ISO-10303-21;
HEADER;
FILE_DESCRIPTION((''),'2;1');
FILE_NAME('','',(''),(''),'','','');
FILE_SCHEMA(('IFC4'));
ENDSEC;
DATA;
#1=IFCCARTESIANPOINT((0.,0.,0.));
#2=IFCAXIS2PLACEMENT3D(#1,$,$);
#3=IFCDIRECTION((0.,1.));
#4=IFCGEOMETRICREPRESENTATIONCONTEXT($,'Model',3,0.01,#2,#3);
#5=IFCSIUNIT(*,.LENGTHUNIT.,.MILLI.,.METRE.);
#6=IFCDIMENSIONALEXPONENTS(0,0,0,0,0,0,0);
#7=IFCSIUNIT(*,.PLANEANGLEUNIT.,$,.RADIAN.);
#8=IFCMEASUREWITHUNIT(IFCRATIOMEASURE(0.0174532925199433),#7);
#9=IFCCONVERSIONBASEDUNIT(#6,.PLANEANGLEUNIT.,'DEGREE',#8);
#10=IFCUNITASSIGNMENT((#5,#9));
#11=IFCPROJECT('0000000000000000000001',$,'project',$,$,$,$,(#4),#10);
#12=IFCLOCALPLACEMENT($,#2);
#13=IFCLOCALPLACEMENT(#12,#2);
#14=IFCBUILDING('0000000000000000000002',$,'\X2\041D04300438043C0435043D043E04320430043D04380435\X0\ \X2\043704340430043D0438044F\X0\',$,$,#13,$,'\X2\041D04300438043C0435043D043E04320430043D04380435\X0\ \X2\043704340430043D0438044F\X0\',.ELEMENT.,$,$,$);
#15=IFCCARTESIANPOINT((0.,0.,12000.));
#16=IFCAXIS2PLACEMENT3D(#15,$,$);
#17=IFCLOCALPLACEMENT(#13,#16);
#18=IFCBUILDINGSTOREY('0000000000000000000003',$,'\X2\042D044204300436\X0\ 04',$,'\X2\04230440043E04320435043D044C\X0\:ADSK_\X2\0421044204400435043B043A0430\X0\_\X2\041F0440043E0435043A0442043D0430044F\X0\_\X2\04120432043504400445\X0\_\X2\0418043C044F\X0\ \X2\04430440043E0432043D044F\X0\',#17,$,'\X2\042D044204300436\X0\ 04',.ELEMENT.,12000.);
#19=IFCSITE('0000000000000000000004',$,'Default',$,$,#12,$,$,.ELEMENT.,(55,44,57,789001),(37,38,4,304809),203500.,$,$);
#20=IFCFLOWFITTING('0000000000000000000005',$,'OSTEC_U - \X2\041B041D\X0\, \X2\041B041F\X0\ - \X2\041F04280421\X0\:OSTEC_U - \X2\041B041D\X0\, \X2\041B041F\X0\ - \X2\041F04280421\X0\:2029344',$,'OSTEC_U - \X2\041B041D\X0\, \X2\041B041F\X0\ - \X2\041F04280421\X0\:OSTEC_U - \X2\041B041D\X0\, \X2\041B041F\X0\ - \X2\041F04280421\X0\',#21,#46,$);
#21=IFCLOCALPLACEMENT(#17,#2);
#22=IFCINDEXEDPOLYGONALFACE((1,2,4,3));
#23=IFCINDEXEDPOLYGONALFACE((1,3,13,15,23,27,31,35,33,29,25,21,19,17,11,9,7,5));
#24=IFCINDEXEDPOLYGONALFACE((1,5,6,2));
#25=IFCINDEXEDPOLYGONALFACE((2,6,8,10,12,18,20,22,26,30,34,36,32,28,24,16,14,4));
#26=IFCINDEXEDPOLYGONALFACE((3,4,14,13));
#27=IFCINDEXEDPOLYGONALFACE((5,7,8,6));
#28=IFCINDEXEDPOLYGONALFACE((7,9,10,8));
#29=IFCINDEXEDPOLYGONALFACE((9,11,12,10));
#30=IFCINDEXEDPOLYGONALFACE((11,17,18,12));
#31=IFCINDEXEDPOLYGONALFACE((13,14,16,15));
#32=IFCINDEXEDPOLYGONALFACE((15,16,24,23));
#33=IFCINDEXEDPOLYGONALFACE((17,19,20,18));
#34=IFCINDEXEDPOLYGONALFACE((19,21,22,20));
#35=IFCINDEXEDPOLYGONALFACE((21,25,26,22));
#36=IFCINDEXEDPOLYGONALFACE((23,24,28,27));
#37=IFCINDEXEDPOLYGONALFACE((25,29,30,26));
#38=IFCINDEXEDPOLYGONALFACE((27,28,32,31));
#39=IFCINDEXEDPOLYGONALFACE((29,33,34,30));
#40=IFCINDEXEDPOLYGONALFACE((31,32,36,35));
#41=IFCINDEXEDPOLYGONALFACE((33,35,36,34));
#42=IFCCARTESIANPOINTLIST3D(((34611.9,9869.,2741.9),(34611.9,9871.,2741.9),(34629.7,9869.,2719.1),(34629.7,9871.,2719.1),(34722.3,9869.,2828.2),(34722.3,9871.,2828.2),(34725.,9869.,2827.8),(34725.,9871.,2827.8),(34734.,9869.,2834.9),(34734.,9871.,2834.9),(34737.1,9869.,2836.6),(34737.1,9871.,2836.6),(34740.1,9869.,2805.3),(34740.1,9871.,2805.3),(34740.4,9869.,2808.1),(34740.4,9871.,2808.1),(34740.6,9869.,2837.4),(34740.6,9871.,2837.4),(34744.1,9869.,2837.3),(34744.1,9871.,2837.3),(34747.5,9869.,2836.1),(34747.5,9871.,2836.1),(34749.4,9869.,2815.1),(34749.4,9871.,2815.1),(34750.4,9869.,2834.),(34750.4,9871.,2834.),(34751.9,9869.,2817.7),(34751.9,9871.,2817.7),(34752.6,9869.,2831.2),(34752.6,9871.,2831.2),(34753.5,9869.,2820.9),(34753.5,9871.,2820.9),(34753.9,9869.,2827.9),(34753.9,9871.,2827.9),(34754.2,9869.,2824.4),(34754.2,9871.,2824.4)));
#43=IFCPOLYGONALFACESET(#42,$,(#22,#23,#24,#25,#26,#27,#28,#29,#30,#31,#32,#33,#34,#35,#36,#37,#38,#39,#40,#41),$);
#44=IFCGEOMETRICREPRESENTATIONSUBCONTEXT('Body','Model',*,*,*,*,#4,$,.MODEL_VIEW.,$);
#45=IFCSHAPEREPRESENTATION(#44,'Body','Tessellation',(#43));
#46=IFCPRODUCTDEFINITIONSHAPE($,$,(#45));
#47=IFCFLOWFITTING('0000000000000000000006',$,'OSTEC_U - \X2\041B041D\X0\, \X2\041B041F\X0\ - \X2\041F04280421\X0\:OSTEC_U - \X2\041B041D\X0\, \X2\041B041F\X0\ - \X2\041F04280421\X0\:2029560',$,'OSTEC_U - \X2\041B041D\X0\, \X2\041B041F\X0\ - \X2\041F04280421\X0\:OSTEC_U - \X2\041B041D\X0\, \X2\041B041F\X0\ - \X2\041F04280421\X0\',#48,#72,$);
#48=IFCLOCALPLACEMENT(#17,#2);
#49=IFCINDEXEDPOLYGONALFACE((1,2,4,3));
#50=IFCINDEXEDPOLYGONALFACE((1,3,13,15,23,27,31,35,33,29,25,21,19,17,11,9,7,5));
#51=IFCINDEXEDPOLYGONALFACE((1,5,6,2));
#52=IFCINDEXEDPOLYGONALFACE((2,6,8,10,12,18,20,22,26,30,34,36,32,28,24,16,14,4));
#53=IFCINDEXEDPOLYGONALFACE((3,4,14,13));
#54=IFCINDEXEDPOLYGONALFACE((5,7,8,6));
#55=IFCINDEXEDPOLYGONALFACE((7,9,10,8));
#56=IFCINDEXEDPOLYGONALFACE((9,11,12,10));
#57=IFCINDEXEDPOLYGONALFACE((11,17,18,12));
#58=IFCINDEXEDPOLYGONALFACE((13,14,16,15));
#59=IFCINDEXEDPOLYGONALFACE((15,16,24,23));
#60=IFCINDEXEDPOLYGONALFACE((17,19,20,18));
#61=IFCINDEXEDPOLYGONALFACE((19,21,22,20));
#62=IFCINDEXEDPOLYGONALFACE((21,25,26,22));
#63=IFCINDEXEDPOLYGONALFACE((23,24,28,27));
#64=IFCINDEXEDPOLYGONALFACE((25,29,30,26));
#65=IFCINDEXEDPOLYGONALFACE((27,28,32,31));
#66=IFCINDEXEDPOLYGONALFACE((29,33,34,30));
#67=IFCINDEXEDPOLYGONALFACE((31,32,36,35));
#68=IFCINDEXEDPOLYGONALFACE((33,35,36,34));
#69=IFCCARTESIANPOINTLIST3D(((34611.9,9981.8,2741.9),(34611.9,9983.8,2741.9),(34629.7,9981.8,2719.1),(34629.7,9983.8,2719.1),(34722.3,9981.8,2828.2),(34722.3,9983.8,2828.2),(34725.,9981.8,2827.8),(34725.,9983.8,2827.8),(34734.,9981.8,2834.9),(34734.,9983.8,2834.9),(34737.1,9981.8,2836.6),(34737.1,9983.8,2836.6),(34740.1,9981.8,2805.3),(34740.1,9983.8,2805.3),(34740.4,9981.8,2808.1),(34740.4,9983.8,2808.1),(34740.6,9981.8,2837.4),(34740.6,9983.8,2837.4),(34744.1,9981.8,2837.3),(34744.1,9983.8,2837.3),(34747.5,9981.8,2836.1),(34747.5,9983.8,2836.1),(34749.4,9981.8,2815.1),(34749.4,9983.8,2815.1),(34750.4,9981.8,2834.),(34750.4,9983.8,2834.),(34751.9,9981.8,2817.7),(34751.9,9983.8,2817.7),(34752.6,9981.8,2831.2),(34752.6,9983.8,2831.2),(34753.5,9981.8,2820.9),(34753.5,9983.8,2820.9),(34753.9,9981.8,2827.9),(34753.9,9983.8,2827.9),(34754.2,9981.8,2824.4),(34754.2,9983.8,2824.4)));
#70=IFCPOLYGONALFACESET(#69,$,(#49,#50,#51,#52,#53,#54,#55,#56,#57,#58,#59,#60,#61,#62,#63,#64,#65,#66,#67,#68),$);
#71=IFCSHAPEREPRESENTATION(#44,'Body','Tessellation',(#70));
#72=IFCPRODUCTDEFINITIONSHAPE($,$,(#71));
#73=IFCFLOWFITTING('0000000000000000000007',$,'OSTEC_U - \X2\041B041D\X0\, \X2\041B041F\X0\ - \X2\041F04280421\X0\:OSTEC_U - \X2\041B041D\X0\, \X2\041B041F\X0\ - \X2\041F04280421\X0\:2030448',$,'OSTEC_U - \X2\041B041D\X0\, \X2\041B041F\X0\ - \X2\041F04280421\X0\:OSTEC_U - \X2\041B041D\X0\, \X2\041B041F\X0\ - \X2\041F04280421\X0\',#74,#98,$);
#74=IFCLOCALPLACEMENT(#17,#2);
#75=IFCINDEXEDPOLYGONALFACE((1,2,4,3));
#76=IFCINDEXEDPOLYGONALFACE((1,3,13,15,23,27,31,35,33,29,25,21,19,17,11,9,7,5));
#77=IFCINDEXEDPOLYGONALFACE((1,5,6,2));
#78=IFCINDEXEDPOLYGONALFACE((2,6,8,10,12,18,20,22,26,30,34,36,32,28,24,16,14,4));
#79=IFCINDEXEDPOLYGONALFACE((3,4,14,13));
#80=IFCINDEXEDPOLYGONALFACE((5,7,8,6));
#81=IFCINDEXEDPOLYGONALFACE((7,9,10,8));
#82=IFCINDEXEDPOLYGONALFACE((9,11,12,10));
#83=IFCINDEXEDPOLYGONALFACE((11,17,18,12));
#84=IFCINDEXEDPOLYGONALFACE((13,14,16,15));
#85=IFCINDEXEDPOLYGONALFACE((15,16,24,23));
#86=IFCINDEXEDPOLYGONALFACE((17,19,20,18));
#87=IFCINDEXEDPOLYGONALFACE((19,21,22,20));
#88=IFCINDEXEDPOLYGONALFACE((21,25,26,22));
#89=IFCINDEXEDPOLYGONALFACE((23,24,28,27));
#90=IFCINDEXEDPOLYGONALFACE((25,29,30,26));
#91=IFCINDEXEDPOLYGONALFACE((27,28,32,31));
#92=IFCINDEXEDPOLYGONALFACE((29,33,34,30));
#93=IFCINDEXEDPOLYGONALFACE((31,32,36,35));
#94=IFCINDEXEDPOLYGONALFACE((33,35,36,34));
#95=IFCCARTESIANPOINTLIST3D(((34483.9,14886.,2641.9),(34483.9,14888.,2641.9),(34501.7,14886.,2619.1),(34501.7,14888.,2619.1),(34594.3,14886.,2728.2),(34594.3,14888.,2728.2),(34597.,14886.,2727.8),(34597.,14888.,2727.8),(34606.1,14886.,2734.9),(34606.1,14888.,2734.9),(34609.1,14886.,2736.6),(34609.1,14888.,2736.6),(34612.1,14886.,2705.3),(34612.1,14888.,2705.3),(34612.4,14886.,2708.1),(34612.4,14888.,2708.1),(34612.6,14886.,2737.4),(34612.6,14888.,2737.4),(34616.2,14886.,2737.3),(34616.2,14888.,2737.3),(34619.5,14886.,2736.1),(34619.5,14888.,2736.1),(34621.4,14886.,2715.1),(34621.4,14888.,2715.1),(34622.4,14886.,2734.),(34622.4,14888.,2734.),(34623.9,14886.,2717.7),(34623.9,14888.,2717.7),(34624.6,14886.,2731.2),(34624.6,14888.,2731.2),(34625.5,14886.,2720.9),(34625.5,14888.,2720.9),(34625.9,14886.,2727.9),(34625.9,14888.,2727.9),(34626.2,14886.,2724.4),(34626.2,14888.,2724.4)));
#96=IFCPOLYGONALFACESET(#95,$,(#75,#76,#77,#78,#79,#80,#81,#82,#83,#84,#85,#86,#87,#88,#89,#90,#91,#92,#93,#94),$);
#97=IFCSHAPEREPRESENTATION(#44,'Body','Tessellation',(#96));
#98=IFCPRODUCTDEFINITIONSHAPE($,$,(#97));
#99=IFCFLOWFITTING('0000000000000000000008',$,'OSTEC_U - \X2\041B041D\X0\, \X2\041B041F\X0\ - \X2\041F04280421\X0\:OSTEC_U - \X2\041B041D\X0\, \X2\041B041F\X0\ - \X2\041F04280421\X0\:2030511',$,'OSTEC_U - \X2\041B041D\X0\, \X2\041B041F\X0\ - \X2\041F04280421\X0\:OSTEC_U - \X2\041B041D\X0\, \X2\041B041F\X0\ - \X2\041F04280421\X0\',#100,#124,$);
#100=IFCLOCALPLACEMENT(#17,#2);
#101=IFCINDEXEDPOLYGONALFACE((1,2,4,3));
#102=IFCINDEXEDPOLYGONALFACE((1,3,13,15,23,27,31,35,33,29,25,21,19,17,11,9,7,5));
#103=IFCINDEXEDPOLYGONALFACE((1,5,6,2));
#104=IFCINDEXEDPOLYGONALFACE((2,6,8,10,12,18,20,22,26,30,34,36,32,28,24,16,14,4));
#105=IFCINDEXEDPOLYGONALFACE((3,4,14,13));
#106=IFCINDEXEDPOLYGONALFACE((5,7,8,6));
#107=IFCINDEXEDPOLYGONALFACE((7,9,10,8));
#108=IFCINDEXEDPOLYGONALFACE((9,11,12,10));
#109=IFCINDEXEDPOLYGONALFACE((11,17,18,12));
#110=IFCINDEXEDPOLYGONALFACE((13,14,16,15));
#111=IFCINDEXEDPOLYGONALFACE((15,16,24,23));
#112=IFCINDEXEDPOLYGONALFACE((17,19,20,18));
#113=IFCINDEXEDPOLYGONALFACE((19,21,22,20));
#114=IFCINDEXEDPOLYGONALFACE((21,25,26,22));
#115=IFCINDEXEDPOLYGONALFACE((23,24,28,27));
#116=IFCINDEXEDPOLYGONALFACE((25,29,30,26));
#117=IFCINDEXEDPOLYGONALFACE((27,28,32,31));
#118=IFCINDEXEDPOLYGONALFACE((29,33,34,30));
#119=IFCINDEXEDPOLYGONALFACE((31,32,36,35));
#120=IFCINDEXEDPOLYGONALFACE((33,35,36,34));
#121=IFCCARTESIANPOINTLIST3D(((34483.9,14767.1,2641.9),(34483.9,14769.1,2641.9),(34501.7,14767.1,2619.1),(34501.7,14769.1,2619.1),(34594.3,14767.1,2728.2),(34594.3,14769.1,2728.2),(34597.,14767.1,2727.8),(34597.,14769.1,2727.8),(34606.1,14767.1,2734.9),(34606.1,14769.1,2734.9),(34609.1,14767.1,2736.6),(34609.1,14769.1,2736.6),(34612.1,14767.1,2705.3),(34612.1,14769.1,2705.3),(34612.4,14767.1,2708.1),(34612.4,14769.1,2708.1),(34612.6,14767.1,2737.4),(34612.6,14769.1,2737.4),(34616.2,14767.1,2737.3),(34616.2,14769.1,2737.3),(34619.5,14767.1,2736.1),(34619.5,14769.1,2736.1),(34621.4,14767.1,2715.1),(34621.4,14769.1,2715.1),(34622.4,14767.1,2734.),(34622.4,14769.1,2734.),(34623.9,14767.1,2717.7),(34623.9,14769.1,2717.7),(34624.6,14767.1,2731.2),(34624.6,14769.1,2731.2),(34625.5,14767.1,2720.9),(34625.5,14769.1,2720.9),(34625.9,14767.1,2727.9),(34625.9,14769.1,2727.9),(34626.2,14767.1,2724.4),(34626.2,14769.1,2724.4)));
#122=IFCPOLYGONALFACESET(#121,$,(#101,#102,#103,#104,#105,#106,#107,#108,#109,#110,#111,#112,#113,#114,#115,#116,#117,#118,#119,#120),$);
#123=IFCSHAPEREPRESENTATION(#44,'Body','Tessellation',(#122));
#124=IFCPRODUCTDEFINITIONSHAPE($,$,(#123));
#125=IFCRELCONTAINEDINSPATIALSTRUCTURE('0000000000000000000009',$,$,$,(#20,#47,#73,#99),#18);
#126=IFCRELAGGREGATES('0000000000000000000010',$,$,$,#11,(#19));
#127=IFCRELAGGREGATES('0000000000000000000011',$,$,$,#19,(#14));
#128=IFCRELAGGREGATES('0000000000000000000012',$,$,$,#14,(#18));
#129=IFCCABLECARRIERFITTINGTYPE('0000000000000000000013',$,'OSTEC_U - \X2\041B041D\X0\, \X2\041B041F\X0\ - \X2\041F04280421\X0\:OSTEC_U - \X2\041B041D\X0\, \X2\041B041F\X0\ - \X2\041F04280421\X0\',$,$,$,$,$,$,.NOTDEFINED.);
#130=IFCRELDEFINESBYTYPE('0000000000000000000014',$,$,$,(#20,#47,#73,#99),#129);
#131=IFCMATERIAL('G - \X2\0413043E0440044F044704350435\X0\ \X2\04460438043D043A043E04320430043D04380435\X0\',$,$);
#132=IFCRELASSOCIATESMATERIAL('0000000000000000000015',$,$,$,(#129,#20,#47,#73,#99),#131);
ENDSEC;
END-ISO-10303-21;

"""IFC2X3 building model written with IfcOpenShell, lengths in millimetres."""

from ifc_helpers import new_model, entity, si_unit, converted_unit, direction, frame, frame_2d, origin, place, context, subcontext, project, spatial, polyline, circle_curve, parameter, trimmed, segment, composite_curve, outline, extrude, source, transform, mapped, material, type_object, type_shapes, element, save


model = new_model("IFC2X3")

# Units and contexts
model_context = context("Model", 3, precision=0.01, world=origin(), true_north=direction((0.0, 1.0)))
body_context = subcontext(model_context, "Body", "Model", "MODEL_VIEW")
ifc_project = project(units=[si_unit("LENGTHUNIT", "METRE", prefix="MILLI"), converted_unit("PLANEANGLEUNIT", "DEGREE", entity("IfcRatioMeasure", 0.0174532925199433), si_unit("PLANEANGLEUNIT", "RADIAN"), dimensions=[0, 0, 0, 0, 0, 0, 0])], contexts=[model_context])

# Site, building, storey
site_placement = place(None, frame((0.0, 0.0, 0.0)))
site = spatial("IfcSite", under=ifc_project, at=site_placement, Name="Default", CompositionType="ELEMENT", RefLatitude=(55, 44, 57, 789001), RefLongitude=(37, 38, 4, 304809), RefElevation=203500.0)
building_placement = place(site_placement, origin())
building = spatial("IfcBuilding", under=site, at=building_placement, Name="Наименование здания", LongName="Наименование здания", CompositionType="ELEMENT")
storey_placement = place(building_placement, frame((0.0, 0.0, 12000.0)))
storey = spatial("IfcBuildingStorey", under=building, at=storey_placement, Name="Этаж 04", ObjectType="Уровень:ADSK_Стрелка_Проектная_Вверх_Имя уровня", LongName="Этаж 04", CompositionType="ELEMENT", Elevation=12000.0)

# Flow fittings
ifc_material = material(Name="G - Горячее цинкование")
cable_carrier_fitting_type_1 = type_object("IfcCableCarrierFittingType", Name="OSTEC_U - ЛН, ЛП - ПШС:OSTEC_U - ЛН, ЛП - ПШС", PredefinedType="NOTDEFINED", material=ifc_material)
shared_shape_1 = source(origin(), body_context, "Body", "SweptSolid", [
    extrude(outline(composite_curve([segment(trimmed(circle_curve(frame_2d((-44.6, 0.0), x_axis=(1.0, 0.0)), 12.5), [parameter(90.0)], [parameter(270.0)], True, "PARAMETER"), True, "CONTINUOUS"), segment(polyline([(-44.6, -12.5), (-33.1, -12.5)]), True, "CONTINUOUS"), segment(polyline([(-33.1, -12.5), (-31.2, -14.5)]), True, "CONTINUOUS"), segment(polyline([(-31.2, -14.5), (108.9, -14.5)]), True, "CONTINUOUS"), segment(polyline([(108.9, -14.5), (108.9, 14.5)]), True, "CONTINUOUS"), segment(polyline([(108.9, 14.5), (-31.2, 14.5)]), True, "CONTINUOUS"), segment(polyline([(-31.2, 14.5), (-33.1, 12.5)]), True, "CONTINUOUS"), segment(polyline([(-33.1, 12.5), (-44.6, 12.5)]), True, "CONTINUOUS")], self_intersect=False)), frame((44.6, 0.0, 0.0)), (0.0, 0.0, 1.0), 2.0),
])
type_shapes(cable_carrier_fitting_type_1, [shared_shape_1])
for number, where, z_axis, x_axis, name in (
    (1, (34741.7, 9869.0, 2825.0), (0.0, 1.0, 0.0), (-0.788011, 0.0, -0.615661), "OSTEC_U - ЛН, ЛП - ПШС:OSTEC_U - ЛН, ЛП - ПШС:2029344"),
    (2, (34741.7, 9981.8, 2825.0), (0.0, 1.0, 0.0), (-0.788011, 0.0, -0.615661), "OSTEC_U - ЛН, ЛП - ПШС:OSTEC_U - ЛН, ЛП - ПШС:2029560"),
    (3, (34613.7, 14886.0, 2725.0), (0.0, 1.0, 0.0), (-0.788011, 0.0, -0.615661), "OSTEC_U - ЛН, ЛП - ПШС:OSTEC_U - ЛН, ЛП - ПШС:2030448"),
    (4, (34613.7, 14767.1, 2725.0), (0.0, 1.0, 0.0), (-0.788011, 0.0, -0.615661), "OSTEC_U - ЛН, ЛП - ПШС:OSTEC_U - ЛН, ЛП - ПШС:2030511"),
):
    element("IfcFlowFitting", number, at=place(storey_placement, frame(where, z_axis=z_axis, x_axis=x_axis)), inside=storey, type_object=cable_carrier_fitting_type_1, material=ifc_material, Name=name, ObjectType="OSTEC_U - ЛН, ЛП - ПШС:OSTEC_U - ЛН, ЛП - ПШС", context=body_context, shape_type="MappedRepresentation", body=[
        mapped(shared_shape_1, transform((0.0, 0.0, 0.0), scale=1.0)),
    ])

save(model, "model.ifc")
